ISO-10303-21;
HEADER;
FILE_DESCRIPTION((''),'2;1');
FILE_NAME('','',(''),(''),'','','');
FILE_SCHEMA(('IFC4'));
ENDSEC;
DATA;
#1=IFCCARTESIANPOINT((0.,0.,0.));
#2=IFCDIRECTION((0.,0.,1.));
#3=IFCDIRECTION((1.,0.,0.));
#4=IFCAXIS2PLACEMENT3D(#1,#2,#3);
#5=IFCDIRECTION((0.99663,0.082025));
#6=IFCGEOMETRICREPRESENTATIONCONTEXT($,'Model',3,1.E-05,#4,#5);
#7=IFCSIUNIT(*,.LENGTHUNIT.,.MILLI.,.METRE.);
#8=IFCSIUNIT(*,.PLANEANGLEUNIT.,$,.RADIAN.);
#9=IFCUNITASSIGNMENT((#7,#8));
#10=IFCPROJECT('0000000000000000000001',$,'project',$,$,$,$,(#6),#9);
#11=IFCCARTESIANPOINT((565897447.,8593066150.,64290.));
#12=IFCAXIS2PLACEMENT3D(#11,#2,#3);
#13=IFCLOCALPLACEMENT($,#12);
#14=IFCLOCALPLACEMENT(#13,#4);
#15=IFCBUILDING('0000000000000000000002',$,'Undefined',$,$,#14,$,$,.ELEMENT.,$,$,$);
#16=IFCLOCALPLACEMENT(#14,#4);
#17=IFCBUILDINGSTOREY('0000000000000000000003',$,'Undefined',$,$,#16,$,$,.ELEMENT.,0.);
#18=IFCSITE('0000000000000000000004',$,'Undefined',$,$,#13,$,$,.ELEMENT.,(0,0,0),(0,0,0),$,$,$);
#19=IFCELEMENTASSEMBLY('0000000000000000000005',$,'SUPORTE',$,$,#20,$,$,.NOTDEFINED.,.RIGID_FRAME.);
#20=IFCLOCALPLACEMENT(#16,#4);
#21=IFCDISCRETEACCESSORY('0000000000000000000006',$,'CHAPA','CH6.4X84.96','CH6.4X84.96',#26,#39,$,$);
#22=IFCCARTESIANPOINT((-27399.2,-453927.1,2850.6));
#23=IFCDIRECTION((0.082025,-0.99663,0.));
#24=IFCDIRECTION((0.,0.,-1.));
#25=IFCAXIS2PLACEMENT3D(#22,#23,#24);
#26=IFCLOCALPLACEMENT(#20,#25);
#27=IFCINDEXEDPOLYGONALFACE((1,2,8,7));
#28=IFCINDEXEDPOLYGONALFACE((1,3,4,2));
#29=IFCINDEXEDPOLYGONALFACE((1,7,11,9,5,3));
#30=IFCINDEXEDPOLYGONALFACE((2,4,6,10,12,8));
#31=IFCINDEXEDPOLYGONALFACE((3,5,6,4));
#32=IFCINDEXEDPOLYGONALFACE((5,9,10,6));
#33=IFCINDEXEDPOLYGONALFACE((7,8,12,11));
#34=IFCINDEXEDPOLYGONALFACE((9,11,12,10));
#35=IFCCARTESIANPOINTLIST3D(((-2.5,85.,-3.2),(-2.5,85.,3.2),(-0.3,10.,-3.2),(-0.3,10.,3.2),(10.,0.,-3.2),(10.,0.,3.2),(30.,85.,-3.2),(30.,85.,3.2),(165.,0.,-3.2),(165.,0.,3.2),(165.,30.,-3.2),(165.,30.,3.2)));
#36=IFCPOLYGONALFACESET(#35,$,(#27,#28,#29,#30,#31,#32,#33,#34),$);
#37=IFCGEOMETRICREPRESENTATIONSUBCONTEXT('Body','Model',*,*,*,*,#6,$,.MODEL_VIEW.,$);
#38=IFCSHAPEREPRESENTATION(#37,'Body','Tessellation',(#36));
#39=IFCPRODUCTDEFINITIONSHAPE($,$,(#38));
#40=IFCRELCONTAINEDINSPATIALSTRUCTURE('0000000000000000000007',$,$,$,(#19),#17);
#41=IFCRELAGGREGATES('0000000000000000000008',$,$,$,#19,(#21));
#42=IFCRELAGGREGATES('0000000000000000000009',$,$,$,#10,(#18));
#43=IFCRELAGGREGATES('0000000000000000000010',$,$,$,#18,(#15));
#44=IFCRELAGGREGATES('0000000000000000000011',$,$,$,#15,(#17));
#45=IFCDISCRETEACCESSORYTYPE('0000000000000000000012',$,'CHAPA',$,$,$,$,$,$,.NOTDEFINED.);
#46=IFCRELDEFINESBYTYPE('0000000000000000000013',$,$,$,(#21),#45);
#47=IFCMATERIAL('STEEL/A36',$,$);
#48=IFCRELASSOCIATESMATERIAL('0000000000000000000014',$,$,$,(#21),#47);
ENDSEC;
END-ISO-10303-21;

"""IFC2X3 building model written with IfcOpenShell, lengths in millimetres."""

from ifc_helpers import new_model, si_unit, direction, frame, origin_with_axes, place, context, subcontext, project, spatial, polyline, outline, extrude, material, type_object, element, aggregate, save


model = new_model("IFC2X3")

# Units and contexts
model_context = context("Model", 3, precision=1e-05, world=origin_with_axes(), true_north=direction((0.99663, 0.082025)))
body_context = subcontext(model_context, "Body", "Model", "MODEL_VIEW")
ifc_project = project(units=[si_unit("LENGTHUNIT", "METRE", prefix="MILLI"), si_unit("PLANEANGLEUNIT", "RADIAN")], contexts=[model_context])

# Site, building, storey
site_placement = place(None, frame((565897447.0, 8593066150.0, 64290.0), z_axis=(0.0, 0.0, 1.0), x_axis=(1.0, 0.0, 0.0)))
site = spatial("IfcSite", under=ifc_project, at=site_placement, Name="Undefined", CompositionType="ELEMENT", RefLatitude=(0, 0, 0), RefLongitude=(0, 0, 0))
building_placement = place(site_placement, origin_with_axes())
building = spatial("IfcBuilding", under=site, at=building_placement, Name="Undefined", CompositionType="ELEMENT")
storey_placement = place(building_placement, origin_with_axes())
storey = spatial("IfcBuildingStorey", under=building, at=storey_placement, Name="Undefined", CompositionType="ELEMENT", Elevation=0.0)

# Shared definitions
ifc_material_1 = material(Name="STEEL/A36")

# Shared definitions
discrete_accessory_type_1 = type_object("IfcDiscreteAccessoryType", Name="CHAPA")

# Element assembly, discrete accessory
assembly_1_placement = place(storey_placement, origin_with_axes())
assembly_1 = element("IfcElementAssembly", 1, at=assembly_1_placement, inside=storey, Name="SUPORTE", AssemblyPlace="NOTDEFINED", PredefinedType="RIGID_FRAME")
discrete_accessory_1_placement = place(assembly_1_placement, frame((-27399.2, -453927.1, 2850.6), z_axis=(0.082025, -0.99663, 0.0), x_axis=(0.0, 0.0, -1.0)))
discrete_accessory_1 = element("IfcDiscreteAccessory", 2, at=discrete_accessory_1_placement, type_object=discrete_accessory_type_1, material=ifc_material_1, Name="CHAPA", Description="CH6.4X84.96", ObjectType="CH6.4X84.96", context=body_context, shape_type="SweptSolid", body=[
    extrude(outline(polyline([(-0.3, 10.0), (10.0, 0.0), (165.0, 0.0), (165.0, 30.0), (30.0, 85.0), (-2.5, 85.0), (-0.3, 10.0)])), frame((0.0, 0.0, -3.2), z_axis=(0.0, 0.0, 1.0), x_axis=(1.0, 0.0, 0.0)), (0.0, 0.0, 1.0), 6.4),
])
aggregate(assembly_1, [discrete_accessory_1])

save(model, "model.ifc")
